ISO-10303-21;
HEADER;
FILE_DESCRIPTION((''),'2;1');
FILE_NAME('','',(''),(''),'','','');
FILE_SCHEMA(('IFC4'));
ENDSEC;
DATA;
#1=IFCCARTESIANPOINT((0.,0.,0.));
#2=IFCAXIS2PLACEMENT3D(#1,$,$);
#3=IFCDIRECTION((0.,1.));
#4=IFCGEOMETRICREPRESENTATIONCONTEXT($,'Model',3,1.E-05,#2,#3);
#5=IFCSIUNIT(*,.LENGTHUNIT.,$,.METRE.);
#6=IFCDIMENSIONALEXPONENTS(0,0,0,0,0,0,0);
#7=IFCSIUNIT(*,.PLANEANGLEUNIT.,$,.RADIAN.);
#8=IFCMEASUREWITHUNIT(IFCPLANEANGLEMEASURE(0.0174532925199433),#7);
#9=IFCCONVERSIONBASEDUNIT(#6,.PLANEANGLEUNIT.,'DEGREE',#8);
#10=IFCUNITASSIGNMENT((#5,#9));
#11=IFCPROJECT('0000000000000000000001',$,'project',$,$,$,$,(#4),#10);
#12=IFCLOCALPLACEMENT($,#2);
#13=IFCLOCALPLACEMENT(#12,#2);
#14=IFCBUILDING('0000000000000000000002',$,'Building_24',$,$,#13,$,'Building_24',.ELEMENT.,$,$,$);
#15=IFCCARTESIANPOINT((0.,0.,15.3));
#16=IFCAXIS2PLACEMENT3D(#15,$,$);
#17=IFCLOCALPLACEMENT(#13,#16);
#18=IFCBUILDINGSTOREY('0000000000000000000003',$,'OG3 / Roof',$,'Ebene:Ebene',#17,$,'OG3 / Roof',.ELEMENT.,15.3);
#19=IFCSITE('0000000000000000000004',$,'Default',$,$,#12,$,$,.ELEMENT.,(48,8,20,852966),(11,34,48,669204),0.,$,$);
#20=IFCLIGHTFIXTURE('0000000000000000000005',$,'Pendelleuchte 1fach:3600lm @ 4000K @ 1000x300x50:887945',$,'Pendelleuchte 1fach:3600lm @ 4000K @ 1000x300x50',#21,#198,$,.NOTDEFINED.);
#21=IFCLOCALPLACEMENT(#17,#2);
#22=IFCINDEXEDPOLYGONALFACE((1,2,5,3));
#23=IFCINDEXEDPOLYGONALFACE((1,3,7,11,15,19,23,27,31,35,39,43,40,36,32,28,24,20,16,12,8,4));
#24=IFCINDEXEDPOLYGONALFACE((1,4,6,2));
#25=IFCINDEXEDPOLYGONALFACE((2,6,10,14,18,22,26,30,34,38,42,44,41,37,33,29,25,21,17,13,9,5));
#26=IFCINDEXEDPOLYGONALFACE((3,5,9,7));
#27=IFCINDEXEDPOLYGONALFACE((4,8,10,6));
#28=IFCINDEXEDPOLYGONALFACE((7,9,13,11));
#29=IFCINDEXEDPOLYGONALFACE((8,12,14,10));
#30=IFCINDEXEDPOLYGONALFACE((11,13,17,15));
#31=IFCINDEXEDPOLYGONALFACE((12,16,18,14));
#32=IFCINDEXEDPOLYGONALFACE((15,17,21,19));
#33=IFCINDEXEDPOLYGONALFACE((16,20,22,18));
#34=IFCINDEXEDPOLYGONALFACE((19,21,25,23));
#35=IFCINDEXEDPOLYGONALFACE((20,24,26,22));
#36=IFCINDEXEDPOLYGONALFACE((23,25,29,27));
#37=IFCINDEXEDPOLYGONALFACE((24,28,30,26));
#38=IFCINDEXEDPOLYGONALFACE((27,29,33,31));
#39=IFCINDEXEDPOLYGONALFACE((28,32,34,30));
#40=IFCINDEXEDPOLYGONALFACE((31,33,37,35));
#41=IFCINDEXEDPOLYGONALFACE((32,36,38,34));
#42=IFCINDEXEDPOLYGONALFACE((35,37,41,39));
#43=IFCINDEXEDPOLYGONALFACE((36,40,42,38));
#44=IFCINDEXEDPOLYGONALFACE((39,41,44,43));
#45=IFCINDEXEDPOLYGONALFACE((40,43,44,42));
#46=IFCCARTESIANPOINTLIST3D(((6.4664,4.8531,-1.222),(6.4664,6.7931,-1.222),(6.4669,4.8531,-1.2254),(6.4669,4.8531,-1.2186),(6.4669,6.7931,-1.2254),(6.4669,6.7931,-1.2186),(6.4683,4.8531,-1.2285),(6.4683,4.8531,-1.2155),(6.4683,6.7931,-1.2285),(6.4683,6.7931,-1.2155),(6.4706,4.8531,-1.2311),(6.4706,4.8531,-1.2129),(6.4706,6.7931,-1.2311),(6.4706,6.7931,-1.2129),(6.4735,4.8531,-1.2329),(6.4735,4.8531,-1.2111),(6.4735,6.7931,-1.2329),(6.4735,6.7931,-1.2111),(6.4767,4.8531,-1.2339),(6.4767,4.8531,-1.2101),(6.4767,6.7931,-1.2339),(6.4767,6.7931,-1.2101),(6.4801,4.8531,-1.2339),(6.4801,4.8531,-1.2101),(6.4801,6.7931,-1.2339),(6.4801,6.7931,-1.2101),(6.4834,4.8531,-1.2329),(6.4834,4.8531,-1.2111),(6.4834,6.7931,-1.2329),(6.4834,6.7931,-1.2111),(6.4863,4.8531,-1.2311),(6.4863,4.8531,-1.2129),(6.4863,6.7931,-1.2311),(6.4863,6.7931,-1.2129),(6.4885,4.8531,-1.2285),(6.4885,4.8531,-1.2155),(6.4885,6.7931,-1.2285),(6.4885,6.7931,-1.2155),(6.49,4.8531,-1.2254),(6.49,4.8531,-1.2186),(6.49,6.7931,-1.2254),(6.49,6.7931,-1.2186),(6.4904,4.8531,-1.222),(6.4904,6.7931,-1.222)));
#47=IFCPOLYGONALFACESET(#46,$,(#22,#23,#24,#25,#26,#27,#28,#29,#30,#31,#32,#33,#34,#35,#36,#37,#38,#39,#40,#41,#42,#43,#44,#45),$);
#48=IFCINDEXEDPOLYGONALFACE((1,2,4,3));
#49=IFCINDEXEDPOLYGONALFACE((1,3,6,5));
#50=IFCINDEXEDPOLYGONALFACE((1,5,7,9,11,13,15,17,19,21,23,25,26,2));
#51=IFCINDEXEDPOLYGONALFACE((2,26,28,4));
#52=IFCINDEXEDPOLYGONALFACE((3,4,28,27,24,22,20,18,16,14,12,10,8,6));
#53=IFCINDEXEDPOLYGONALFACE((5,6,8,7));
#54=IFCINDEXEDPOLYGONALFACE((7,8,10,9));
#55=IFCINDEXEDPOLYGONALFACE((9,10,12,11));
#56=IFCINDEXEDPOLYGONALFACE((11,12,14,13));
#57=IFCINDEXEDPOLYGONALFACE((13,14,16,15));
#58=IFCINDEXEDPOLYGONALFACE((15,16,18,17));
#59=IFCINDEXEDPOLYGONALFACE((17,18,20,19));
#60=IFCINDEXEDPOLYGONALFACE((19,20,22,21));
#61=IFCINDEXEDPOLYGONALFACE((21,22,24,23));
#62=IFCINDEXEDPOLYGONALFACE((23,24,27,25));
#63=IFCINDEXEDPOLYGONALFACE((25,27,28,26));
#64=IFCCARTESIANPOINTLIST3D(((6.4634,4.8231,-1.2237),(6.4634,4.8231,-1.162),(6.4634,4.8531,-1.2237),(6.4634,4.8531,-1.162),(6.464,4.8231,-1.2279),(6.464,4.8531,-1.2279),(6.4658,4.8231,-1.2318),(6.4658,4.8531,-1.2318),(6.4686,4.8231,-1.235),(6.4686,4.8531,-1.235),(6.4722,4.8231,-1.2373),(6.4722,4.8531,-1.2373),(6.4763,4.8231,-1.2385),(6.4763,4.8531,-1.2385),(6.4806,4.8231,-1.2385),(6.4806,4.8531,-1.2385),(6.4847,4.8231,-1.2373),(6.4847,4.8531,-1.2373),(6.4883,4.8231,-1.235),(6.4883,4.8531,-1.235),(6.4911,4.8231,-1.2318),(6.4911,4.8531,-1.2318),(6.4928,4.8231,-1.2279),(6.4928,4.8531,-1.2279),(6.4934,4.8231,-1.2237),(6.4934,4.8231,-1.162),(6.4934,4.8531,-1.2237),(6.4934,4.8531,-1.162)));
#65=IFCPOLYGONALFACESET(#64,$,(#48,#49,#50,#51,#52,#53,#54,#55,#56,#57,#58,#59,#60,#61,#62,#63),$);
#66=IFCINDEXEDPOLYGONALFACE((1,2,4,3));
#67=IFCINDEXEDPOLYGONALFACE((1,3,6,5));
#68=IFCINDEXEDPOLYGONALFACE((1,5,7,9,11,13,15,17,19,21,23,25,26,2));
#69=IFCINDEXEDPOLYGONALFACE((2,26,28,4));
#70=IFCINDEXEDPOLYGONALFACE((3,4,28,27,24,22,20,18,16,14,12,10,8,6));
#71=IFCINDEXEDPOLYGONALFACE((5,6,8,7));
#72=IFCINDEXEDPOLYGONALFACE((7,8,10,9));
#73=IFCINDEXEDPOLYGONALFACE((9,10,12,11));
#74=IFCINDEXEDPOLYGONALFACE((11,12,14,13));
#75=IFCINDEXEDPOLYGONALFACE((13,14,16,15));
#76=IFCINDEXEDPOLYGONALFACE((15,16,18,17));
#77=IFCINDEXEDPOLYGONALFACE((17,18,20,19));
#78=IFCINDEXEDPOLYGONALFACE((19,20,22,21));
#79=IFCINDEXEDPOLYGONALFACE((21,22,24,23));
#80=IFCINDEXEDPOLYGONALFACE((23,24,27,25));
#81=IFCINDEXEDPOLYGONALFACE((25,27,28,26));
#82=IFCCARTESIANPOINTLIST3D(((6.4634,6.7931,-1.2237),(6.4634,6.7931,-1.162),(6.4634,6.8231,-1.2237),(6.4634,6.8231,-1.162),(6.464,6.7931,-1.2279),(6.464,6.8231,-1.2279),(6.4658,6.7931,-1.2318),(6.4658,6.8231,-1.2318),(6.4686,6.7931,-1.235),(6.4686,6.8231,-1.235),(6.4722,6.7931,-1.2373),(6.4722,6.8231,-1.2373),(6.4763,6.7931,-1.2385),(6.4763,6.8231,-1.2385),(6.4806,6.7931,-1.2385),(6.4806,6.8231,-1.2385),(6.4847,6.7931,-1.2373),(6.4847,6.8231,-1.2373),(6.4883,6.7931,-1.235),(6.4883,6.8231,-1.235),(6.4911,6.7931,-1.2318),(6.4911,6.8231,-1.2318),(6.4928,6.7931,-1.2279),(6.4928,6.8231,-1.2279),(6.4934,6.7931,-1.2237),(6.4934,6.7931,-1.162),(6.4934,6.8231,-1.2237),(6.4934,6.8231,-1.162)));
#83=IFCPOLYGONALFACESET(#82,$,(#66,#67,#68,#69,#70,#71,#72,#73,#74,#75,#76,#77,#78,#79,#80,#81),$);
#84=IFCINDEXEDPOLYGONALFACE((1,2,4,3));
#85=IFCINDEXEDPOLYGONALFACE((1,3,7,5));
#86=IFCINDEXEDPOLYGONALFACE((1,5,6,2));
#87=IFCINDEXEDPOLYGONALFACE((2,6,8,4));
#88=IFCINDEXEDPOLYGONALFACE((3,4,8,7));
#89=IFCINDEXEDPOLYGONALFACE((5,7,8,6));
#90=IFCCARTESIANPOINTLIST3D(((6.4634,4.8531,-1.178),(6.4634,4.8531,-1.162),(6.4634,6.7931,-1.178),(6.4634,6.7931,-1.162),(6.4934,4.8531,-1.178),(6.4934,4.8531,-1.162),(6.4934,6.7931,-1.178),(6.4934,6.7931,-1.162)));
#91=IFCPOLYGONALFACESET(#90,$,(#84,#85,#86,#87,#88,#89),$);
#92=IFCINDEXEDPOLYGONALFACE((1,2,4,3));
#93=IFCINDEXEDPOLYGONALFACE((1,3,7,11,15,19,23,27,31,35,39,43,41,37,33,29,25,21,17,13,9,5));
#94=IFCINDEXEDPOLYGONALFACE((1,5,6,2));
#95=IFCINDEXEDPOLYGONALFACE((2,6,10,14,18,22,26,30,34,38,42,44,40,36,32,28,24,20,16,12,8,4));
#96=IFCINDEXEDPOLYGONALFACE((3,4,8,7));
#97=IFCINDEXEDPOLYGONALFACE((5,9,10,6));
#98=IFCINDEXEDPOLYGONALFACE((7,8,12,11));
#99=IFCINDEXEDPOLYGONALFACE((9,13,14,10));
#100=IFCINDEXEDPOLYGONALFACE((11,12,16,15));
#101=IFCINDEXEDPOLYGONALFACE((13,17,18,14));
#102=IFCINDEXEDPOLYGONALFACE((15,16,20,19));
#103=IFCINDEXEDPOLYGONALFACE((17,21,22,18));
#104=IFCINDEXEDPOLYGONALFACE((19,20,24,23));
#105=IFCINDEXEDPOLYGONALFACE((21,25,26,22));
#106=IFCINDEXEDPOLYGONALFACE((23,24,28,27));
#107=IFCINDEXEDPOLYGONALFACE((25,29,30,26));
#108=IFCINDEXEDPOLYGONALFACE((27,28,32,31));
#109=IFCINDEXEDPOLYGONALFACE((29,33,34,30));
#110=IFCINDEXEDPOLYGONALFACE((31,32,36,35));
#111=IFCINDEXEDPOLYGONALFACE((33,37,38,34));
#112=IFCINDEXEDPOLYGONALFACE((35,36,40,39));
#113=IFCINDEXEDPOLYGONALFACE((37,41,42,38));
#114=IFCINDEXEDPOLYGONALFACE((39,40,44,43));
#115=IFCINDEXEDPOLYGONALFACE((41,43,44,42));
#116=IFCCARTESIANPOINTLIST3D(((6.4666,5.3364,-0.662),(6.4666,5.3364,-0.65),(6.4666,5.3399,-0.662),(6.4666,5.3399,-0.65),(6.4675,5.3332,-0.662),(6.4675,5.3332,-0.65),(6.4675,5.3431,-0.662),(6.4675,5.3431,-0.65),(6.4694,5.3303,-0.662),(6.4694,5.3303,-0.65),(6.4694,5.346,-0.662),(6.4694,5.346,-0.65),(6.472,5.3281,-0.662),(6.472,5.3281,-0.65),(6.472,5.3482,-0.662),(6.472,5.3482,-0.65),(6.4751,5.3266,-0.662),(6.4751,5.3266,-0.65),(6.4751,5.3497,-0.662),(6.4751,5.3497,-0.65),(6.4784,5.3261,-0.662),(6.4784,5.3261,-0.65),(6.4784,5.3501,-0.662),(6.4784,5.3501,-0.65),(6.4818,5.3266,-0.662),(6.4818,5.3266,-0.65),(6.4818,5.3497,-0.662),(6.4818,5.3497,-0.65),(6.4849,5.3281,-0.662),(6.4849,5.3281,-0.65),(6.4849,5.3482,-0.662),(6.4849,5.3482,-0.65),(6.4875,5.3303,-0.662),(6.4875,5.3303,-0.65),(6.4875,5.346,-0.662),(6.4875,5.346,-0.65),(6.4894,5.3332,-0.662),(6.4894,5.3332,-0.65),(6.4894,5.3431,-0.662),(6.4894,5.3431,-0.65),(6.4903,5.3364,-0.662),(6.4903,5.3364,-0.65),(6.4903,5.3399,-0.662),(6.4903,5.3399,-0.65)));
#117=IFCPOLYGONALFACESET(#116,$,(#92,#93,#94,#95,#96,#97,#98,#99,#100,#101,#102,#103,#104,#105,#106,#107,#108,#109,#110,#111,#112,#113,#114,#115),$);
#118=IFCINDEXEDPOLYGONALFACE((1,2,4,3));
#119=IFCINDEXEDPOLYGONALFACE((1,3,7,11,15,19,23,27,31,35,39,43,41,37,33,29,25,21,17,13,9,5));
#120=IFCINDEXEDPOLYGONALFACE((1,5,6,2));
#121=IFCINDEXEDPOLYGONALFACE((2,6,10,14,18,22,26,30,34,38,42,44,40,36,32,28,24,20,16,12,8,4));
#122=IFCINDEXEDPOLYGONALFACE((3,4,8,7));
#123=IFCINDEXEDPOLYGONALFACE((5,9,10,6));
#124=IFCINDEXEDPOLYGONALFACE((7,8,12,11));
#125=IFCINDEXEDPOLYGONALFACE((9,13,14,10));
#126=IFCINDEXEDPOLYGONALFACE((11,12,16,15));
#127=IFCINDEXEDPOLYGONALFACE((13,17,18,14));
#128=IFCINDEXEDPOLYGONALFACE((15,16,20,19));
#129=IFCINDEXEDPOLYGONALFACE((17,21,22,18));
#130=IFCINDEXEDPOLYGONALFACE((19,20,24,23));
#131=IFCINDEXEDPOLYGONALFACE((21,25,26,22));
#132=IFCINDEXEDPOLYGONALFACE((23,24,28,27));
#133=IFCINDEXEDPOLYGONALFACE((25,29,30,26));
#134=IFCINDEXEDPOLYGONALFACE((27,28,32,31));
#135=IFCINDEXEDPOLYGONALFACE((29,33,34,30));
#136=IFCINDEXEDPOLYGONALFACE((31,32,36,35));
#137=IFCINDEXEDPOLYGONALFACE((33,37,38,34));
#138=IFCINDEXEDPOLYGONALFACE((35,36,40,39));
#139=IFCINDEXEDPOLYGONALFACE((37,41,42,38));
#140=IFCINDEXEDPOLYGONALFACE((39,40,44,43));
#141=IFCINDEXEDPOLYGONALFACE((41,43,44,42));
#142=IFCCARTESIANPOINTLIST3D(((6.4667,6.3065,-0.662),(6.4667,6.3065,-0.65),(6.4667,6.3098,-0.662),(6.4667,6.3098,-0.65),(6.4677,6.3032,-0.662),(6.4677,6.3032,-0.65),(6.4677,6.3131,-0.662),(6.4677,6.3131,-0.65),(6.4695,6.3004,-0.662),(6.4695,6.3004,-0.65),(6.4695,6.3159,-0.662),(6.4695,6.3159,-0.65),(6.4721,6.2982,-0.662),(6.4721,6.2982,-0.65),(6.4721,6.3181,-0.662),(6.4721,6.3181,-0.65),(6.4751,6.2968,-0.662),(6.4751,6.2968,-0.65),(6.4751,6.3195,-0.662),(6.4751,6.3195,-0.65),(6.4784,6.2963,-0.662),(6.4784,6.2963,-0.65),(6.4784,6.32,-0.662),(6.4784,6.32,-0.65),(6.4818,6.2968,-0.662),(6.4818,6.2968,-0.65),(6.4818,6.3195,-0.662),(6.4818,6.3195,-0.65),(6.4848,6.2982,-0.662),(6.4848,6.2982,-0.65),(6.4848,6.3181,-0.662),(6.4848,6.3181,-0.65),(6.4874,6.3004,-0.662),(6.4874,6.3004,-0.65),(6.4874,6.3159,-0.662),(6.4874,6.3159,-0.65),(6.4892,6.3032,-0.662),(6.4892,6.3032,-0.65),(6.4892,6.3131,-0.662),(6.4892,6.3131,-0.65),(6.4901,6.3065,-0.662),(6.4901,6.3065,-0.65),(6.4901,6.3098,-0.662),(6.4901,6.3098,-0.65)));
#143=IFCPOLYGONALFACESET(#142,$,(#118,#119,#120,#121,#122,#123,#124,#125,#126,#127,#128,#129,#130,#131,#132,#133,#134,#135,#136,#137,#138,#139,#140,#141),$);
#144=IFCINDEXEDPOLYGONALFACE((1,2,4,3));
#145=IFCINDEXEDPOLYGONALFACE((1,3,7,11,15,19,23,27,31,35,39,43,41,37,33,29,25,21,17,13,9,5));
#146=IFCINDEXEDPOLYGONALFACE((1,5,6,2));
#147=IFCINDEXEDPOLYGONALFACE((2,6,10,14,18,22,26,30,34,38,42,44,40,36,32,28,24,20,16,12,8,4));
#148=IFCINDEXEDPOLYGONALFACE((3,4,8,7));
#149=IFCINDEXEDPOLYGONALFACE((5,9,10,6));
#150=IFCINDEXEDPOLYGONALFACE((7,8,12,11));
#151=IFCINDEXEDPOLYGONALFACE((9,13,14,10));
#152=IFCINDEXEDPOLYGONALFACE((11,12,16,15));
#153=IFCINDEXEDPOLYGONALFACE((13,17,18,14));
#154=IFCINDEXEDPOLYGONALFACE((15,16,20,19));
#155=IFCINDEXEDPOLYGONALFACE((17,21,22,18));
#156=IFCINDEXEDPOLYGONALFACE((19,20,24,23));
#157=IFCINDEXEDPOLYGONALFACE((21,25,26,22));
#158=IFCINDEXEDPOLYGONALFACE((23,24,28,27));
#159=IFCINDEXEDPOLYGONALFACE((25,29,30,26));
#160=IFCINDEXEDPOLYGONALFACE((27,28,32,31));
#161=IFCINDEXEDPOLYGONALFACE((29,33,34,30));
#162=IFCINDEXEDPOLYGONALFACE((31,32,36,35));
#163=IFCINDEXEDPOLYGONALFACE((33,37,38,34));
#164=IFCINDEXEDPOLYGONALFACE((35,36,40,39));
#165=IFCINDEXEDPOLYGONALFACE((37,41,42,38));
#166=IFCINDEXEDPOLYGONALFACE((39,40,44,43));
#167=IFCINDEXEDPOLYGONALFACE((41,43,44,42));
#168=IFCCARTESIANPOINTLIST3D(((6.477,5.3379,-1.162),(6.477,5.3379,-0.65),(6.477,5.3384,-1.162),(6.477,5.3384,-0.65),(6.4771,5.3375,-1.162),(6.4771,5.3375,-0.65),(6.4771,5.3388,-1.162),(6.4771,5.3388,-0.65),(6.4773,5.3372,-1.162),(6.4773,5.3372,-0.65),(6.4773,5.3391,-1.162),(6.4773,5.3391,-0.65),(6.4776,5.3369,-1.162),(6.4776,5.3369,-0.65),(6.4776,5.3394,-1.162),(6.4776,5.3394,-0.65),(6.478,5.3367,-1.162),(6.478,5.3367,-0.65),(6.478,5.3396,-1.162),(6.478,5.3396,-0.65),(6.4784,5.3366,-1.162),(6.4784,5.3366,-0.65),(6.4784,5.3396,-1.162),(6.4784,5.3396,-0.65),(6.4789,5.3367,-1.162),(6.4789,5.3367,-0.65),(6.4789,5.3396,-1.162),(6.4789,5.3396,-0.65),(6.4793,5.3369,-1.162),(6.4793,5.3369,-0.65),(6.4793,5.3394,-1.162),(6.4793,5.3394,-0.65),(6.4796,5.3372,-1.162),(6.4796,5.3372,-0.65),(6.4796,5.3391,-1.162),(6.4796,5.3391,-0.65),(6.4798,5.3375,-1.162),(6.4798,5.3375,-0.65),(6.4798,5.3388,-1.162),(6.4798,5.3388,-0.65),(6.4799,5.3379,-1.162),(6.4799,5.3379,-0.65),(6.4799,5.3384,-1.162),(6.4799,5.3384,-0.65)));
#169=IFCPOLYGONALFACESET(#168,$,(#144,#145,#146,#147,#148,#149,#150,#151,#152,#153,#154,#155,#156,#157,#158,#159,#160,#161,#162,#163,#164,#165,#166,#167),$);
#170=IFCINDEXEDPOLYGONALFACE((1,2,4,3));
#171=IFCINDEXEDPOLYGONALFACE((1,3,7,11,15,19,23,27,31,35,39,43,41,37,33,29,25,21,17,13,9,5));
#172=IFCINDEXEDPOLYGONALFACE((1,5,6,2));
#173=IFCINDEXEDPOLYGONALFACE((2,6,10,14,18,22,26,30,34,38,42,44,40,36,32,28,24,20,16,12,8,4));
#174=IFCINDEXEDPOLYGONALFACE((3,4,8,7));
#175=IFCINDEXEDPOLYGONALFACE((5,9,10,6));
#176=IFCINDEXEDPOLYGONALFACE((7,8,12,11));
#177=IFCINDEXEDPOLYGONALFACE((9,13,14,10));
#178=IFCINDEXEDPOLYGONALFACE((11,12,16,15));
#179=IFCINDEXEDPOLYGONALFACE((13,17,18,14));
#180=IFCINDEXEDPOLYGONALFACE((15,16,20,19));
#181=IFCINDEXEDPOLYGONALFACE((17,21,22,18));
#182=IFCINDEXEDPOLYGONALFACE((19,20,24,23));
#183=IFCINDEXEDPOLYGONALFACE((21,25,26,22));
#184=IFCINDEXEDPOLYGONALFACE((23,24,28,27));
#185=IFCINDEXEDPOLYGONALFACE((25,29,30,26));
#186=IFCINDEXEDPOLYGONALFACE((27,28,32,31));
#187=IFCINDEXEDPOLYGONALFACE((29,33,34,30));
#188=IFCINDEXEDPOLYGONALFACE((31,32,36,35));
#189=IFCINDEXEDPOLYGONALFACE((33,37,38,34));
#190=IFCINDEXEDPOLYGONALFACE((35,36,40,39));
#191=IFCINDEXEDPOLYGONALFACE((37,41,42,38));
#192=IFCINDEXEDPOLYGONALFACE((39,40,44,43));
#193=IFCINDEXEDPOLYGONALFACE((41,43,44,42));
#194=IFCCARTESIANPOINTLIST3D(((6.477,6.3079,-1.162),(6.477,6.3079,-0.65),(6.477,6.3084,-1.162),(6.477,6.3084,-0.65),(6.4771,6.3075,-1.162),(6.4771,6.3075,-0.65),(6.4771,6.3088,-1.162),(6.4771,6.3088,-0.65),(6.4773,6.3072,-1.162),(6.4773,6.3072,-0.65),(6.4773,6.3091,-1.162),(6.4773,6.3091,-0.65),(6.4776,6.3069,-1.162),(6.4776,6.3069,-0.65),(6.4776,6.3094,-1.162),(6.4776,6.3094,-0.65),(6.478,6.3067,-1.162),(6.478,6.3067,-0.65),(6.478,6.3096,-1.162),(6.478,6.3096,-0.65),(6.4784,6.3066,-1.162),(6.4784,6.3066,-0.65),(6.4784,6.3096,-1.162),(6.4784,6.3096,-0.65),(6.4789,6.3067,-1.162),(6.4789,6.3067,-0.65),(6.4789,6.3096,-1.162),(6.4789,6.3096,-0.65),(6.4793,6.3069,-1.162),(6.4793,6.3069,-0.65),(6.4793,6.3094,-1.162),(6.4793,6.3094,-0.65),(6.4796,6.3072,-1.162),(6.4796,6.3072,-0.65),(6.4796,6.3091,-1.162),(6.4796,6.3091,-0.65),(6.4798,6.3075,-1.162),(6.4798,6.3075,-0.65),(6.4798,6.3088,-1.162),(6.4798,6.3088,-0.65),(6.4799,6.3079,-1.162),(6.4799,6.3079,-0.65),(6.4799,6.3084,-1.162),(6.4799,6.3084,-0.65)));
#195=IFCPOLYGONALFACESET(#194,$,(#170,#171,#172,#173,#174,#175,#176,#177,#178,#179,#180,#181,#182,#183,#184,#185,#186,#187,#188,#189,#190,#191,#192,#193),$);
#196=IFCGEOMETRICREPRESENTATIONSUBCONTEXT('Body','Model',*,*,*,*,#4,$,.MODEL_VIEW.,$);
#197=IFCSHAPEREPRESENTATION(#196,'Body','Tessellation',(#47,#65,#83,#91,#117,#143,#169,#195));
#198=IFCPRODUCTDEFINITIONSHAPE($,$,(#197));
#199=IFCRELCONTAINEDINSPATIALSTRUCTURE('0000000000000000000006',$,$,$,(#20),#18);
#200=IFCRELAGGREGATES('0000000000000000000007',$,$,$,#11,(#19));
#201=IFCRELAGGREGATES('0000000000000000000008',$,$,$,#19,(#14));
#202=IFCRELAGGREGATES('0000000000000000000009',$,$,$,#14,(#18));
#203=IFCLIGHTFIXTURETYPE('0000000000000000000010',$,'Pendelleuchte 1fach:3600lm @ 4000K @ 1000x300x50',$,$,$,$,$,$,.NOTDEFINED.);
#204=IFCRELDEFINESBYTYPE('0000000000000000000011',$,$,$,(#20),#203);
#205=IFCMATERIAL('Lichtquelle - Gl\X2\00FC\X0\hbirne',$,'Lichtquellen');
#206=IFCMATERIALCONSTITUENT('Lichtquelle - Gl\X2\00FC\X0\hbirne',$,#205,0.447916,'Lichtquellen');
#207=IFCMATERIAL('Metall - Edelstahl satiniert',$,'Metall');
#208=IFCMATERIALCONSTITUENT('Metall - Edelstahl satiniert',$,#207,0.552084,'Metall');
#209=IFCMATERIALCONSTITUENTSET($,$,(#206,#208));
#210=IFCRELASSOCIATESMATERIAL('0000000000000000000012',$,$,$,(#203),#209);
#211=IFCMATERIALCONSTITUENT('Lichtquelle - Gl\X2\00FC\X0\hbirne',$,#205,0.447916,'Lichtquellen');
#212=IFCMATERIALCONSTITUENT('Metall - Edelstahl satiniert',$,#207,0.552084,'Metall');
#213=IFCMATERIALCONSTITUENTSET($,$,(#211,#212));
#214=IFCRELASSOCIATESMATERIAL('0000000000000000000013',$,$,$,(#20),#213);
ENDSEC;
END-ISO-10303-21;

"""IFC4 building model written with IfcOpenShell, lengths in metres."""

from ifc_helpers import new_model, entity, si_unit, converted_unit, direction, frame, origin, place, context, subcontext, project, spatial, line, arc, indexed_curve, outline, extrude, source, transform, mapped, material, constituent, constituent_set, type_object, type_shapes, element, save


model = new_model("IFC4")

# Units and contexts
model_context = context("Model", 3, precision=1e-05, world=origin(), true_north=direction((0.0, 1.0)))
body_context = subcontext(model_context, "Body", "Model", "MODEL_VIEW")
ifc_project = project(units=[si_unit("LENGTHUNIT", "METRE"), converted_unit("PLANEANGLEUNIT", "DEGREE", entity("IfcPlaneAngleMeasure", 0.0174532925199433), si_unit("PLANEANGLEUNIT", "RADIAN"), dimensions=[0, 0, 0, 0, 0, 0, 0])], contexts=[model_context])

# Site, building, storey
site_placement = place(None, origin())
site = spatial("IfcSite", under=ifc_project, at=site_placement, Name="Default", CompositionType="ELEMENT", RefLatitude=(48, 8, 20, 852966), RefLongitude=(11, 34, 48, 669204), RefElevation=0.0)
building_placement = place(site_placement, origin())
building = spatial("IfcBuilding", under=site, at=building_placement, Name="Building_24", LongName="Building_24", CompositionType="ELEMENT")
storey_placement = place(building_placement, frame((0.0, 0.0, 15.3)))
storey = spatial("IfcBuildingStorey", under=building, at=storey_placement, Name="OG3 / Roof", ObjectType="Ebene:Ebene", LongName="OG3 / Roof", CompositionType="ELEMENT", Elevation=15.3)

# Light fixture
ifc_material_1 = material(Name="Lichtquelle - Glühbirne", Category="Lichtquellen")
ifc_material_2 = material(Name="Metall - Edelstahl satiniert", Category="Metall")
ifc_constituent_1 = constituent(ifc_material_1, Name="Lichtquelle - Glühbirne", Category="Lichtquellen", fraction=0.447916)
ifc_constituent_2 = constituent(ifc_material_2, Name="Metall - Edelstahl satiniert", Category="Metall", fraction=0.552084)
ifc_constituent_set_1 = constituent_set(constituents=[ifc_constituent_1, ifc_constituent_2])
light_fixture_type_1 = type_object("IfcLightFixtureType", Name="Pendelleuchte 1fach:3600lm @ 4000K @ 1000x300x50", PredefinedType="NOTDEFINED", material=ifc_constituent_set_1)
shared_shape_1 = source(origin(), body_context, "Body", "SweptSolid", [
    extrude(outline(indexed_curve([(-0.012, 0.0), (0.0, -0.012), (0.012, 0.0), (0.0, 0.012)], segments=[arc(1, 2, 3), arc(3, 4, 1)], self_intersect=False)), frame((-0.97, 0.0, -0.572), z_axis=(1.0, 0.0, 0.0), x_axis=(0.0, -1.0, 0.0)), (0.0, 0.0, 1.0), 1.94),
    extrude(outline(indexed_curve([(0.015, 0.0308), (0.0, 0.0458), (-0.015, 0.0308), (-0.015, -0.0308), (0.015, -0.0308)], segments=[arc(1, 2, 3), line(3, 4, 5, 1)], self_intersect=False)), frame((0.97, 0.0, -0.5428), z_axis=(1.0, 0.0, 0.0), x_axis=(0.0, -1.0, 0.0)), (0.0, 0.0, 1.0), 0.03),
    extrude(outline(indexed_curve([(0.015, 0.0308), (0.0, 0.0458), (-0.015, 0.0308), (-0.015, -0.0308), (0.015, -0.0308)], segments=[arc(1, 2, 3), line(3, 4, 5, 1)], self_intersect=False)), frame((-1.0, 0.0, -0.5428), z_axis=(1.0, 0.0, 0.0), x_axis=(0.0, -1.0, 0.0)), (0.0, 0.0, 1.0), 0.03),
    extrude(outline(indexed_curve([(-0.015, -0.97), (0.015, -0.97), (0.015, 0.97), (-0.015, 0.97), (-0.015, -0.97)], self_intersect=False)), frame((0.0, 0.0, -0.528), z_axis=(0.0, 0.0, 1.0), x_axis=(0.0, 1.0, 0.0)), (0.0, 0.0, 1.0), 0.016),
    extrude(outline(indexed_curve([(-0.012, 0.0), (0.0, -0.012), (0.012, 0.0), (0.0, 0.012)], segments=[arc(1, 2, 3), arc(3, 4, 1)], self_intersect=False)), frame((0.485, 0.0, -0.012)), (0.0, 0.0, 1.0), 0.012),
    extrude(outline(indexed_curve([(-0.0118, 0.0), (0.0, -0.0118), (0.0118, 0.0), (0.0, 0.0118)], segments=[arc(1, 2, 3), arc(3, 4, 1)], self_intersect=False)), frame((-0.485, 0.0, -0.012)), (0.0, 0.0, 1.0), 0.012),
    extrude(outline(indexed_curve([(-0.0015, 0.0), (0.0, -0.0015), (0.0015, 0.0), (0.0, 0.0015)], segments=[arc(1, 2, 3), arc(3, 4, 1)], self_intersect=False)), frame((0.485, 0.0, -0.512)), (0.0, 0.0, 1.0), 0.512),
    extrude(outline(indexed_curve([(-0.0015, 0.0), (0.0, -0.0015), (0.0015, 0.0), (0.0, 0.0015)], segments=[arc(1, 2, 3), arc(3, 4, 1)], self_intersect=False)), frame((-0.485, 0.0, -0.512)), (0.0, 0.0, 1.0), 0.512),
])
type_shapes(light_fixture_type_1, [shared_shape_1])
ifc_constituent_3 = constituent(ifc_material_1, Name="Lichtquelle - Glühbirne", Category="Lichtquellen", fraction=0.447916)
ifc_constituent_4 = constituent(ifc_material_2, Name="Metall - Edelstahl satiniert", Category="Metall", fraction=0.552084)
ifc_constituent_set_2 = constituent_set(constituents=[ifc_constituent_3, ifc_constituent_4])
light_fixture_1_placement = place(storey_placement, frame((6.4784, 5.8231, -0.65), z_axis=(0.0, 0.0, 1.0), x_axis=(0.0, -1.0, 0.0)))
element("IfcLightFixture", 1, at=light_fixture_1_placement, inside=storey, type_object=light_fixture_type_1, material=ifc_constituent_set_2, Name="Pendelleuchte 1fach:3600lm @ 4000K @ 1000x300x50:887945", ObjectType="Pendelleuchte 1fach:3600lm @ 4000K @ 1000x300x50", PredefinedType="NOTDEFINED", context=body_context, shape_type="MappedRepresentation", body=[
    mapped(shared_shape_1, transform((0.0, 0.0, 0.0), scale=1.0)),
])

save(model, "model.ifc")
